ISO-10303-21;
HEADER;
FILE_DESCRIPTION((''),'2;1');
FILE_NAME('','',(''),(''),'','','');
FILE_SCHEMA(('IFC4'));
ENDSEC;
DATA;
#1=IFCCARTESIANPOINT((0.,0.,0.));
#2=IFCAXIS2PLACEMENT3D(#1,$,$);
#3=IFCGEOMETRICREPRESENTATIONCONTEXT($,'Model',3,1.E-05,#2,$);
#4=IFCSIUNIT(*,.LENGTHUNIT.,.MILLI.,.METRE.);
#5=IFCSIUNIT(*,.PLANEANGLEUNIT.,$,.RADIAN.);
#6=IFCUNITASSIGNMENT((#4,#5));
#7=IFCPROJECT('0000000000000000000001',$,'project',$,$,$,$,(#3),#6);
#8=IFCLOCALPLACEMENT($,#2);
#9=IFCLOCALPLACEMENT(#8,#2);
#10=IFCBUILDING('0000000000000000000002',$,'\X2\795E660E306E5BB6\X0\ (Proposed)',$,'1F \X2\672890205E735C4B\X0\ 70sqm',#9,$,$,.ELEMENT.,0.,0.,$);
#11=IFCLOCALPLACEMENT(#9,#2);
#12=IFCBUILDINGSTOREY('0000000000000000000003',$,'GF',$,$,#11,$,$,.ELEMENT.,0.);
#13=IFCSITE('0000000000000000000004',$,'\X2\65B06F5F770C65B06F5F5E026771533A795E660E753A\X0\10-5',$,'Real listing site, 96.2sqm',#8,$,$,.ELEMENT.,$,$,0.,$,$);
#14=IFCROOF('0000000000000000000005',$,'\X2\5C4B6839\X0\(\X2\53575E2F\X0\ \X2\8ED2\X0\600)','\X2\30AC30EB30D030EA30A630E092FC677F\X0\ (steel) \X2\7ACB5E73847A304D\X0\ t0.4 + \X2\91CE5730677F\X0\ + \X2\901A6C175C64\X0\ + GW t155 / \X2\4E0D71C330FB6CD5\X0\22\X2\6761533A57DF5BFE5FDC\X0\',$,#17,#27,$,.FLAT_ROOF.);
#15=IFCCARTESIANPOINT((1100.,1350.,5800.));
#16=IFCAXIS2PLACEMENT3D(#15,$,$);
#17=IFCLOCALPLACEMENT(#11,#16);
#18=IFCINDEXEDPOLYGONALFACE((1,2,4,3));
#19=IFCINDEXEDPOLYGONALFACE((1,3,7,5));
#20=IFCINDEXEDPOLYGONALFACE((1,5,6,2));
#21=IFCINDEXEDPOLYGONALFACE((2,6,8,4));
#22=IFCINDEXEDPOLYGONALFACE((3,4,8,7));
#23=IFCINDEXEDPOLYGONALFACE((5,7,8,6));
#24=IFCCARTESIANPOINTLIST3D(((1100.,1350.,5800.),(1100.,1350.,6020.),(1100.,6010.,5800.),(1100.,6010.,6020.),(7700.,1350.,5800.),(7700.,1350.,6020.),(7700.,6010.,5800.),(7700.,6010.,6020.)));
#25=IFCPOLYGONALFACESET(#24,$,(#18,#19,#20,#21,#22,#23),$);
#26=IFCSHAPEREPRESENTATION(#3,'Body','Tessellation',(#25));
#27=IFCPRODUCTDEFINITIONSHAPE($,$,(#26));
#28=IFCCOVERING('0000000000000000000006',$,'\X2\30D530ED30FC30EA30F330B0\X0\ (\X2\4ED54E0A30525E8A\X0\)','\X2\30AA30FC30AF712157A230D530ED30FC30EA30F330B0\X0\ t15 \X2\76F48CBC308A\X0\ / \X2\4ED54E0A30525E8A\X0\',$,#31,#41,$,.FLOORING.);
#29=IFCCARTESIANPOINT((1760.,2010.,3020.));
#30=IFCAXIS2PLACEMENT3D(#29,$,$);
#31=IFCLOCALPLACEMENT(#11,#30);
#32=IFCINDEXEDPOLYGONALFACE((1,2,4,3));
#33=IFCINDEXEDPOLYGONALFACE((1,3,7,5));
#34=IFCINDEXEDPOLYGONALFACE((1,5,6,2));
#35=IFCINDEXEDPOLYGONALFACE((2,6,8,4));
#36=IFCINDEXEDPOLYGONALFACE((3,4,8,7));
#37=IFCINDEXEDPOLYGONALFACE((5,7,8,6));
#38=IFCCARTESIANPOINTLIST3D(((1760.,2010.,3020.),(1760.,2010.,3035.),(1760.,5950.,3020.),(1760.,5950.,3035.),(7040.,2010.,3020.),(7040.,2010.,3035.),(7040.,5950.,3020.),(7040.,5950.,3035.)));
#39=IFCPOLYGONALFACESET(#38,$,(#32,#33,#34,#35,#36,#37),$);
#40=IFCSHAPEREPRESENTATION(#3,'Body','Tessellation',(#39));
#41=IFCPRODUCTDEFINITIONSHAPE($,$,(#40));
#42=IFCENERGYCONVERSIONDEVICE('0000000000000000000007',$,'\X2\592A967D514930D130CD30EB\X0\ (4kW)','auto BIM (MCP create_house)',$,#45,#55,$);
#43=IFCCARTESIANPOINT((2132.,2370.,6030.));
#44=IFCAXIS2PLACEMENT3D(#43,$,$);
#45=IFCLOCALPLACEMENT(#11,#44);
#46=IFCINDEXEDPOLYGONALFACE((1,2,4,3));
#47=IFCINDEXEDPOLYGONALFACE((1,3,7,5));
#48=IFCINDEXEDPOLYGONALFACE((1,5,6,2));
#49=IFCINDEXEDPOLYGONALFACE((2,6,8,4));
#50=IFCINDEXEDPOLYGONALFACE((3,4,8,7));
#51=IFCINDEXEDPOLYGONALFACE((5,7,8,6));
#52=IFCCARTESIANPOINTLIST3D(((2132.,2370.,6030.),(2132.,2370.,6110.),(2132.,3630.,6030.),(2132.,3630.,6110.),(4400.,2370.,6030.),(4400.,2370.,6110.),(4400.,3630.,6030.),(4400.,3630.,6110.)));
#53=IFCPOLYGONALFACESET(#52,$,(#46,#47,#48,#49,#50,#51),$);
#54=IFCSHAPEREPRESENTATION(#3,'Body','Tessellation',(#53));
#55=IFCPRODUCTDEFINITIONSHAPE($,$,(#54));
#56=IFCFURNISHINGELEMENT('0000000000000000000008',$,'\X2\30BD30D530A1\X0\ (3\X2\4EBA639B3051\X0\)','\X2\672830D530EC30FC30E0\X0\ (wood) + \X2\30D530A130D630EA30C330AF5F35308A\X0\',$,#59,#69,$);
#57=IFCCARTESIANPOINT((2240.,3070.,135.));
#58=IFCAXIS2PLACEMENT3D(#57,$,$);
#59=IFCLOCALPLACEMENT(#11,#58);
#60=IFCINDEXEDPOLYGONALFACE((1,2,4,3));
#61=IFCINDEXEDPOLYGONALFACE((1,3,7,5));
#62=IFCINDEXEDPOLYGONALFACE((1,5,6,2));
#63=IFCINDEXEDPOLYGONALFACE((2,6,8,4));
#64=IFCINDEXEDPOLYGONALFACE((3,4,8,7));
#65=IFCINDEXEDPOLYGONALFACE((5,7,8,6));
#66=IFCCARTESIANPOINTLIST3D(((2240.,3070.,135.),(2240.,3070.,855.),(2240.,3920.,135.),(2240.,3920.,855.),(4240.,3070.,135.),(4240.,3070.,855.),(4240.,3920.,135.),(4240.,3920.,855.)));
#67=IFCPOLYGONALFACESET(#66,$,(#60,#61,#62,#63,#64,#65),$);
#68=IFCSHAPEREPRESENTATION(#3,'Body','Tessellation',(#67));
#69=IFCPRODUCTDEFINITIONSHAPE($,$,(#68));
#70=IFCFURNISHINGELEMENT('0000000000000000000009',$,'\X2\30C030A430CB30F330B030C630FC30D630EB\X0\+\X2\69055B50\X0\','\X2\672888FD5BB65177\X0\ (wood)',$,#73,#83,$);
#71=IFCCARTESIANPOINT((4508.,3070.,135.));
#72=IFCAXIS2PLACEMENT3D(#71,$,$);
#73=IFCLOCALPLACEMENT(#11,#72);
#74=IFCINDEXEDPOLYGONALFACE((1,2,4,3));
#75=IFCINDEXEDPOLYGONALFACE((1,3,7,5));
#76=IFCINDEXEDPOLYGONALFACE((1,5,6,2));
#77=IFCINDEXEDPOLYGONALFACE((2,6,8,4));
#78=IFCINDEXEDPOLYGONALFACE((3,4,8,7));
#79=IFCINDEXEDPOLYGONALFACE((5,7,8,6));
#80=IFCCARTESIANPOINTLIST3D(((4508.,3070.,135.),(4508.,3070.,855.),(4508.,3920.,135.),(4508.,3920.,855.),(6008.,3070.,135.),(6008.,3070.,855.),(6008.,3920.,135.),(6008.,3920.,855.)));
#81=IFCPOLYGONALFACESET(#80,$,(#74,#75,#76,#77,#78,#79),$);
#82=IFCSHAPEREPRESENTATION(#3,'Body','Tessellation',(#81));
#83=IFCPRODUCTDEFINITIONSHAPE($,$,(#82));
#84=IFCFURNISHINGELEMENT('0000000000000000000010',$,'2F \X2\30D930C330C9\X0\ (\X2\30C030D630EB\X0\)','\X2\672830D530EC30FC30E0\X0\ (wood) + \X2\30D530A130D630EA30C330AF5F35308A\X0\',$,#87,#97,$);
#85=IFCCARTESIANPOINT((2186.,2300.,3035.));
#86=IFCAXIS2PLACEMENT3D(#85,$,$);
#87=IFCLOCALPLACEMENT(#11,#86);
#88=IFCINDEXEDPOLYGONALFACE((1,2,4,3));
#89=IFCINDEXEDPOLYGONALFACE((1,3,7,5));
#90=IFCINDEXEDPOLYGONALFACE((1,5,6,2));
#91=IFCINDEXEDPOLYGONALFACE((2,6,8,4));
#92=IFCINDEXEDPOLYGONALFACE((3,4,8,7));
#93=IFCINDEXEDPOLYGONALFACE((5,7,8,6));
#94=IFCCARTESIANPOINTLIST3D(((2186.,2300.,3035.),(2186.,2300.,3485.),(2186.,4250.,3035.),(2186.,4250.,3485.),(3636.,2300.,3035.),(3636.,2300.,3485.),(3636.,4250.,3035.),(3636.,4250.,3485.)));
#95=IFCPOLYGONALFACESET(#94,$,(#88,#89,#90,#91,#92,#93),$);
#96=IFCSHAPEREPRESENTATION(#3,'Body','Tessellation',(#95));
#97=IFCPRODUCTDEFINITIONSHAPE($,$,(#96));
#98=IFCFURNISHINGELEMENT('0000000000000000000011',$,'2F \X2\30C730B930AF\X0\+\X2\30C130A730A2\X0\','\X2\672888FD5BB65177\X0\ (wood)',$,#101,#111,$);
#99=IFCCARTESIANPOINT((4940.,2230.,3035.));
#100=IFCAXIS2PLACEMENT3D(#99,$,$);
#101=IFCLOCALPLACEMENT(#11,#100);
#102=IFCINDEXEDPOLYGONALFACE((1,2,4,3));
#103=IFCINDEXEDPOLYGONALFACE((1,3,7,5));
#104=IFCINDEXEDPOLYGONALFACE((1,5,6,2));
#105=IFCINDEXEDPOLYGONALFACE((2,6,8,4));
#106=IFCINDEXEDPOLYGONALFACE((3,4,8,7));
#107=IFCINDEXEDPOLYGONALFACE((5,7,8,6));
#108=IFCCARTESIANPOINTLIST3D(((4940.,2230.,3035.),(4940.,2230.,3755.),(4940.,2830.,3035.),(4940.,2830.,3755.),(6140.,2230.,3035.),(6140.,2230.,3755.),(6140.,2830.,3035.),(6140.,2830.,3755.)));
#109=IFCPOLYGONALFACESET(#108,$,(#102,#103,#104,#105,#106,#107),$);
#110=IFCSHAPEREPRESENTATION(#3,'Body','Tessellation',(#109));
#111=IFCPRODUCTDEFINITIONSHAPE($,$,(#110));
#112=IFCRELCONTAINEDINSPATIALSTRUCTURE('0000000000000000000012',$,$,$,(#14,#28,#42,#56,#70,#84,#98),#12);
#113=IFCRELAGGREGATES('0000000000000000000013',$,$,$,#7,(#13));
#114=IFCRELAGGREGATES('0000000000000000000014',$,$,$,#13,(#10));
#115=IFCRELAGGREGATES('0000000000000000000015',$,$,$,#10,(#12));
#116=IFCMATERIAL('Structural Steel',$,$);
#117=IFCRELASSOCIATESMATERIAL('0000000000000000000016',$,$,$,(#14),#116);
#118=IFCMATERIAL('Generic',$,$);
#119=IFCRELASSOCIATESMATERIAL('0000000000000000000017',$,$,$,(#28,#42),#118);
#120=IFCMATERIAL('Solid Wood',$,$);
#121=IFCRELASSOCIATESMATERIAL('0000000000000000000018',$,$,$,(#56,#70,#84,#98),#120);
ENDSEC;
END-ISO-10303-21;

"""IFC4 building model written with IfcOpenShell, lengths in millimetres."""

from ifc_helpers import new_model, si_unit, frame, frame_2d, origin, place, context, project, spatial, rectangle, extrude, material, element, save


model = new_model("IFC4")

# Units and contexts
model_context = context("Model", 3, precision=1e-05, world=origin())
ifc_project = project(units=[si_unit("LENGTHUNIT", "METRE", prefix="MILLI"), si_unit("PLANEANGLEUNIT", "RADIAN")], contexts=[model_context])

# Site, building, storey
site_placement = place(None, origin())
site = spatial("IfcSite", under=ifc_project, at=site_placement, Name="新潟県新潟市東区神明町10-5", ObjectType="Real listing site, 96.2sqm", CompositionType="ELEMENT", RefElevation=0.0)
building_placement = place(site_placement, origin())
building = spatial("IfcBuilding", under=site, at=building_placement, Name="神明の家 (Proposed)", ObjectType="1F 木造平屋 70sqm", CompositionType="ELEMENT", ElevationOfRefHeight=0.0, ElevationOfTerrain=0.0)
storey_placement = place(building_placement, origin())
storey = spatial("IfcBuildingStorey", under=building, at=storey_placement, Name="GF", CompositionType="ELEMENT", Elevation=0.0)

# Shared definitions
ifc_material_1 = material(Name="Solid Wood")

# Shared definitions
ifc_material_2 = material(Name="Generic")

# Roof
ifc_material_3 = material(Name="Structural Steel")
for number, where, name in (
    (1, (1100.0, 1350.0, 5800.0), "屋根(南帯 軒600)"),
):
    element("IfcRoof", number, at=place(storey_placement, frame(where)), inside=storey, material=ifc_material_3, Name=name, Description="ガルバリウム鋼板 (steel) 立平葺き t0.4 + 野地板 + 通気層 + GW t155 / 不燃・法22条区域対応", PredefinedType="FLAT_ROOF", context=model_context, shape_type="SweptSolid", body=[
        extrude(rectangle(XDim=6600.0, YDim=4660.0, at=frame_2d((3300.0, 2330.0))), frame((1100.0, 1350.0, 5800.0)), (0.0, 0.0, 1.0), 220.0),
    ])

# Covering
covering_placement = place(storey_placement, frame((1760.0, 2010.0, 3020.0)))
element("IfcCovering", 2, at=covering_placement, inside=storey, material=ifc_material_2, Name="フローリング (仕上げ床)", Description="オーク無垢フローリング t15 直貼り / 仕上げ床", PredefinedType="FLOORING", context=model_context, shape_type="SweptSolid", body=[
    extrude(rectangle(XDim=5280.0, YDim=3940.0, at=frame_2d((2640.0, 1970.0))), frame((1760.0, 2010.0, 3020.0)), (0.0, 0.0, 1.0), 15.0),
])

# Energy conversion device
energy_conversion_device_placement = place(storey_placement, frame((2132.0, 2370.0, 6030.0)))
element("IfcEnergyConversionDevice", 3, at=energy_conversion_device_placement, inside=storey, material=ifc_material_2, Name="太陽光パネル (4kW)", Description="auto BIM (MCP create_house)", context=model_context, shape_type="SweptSolid", body=[
    extrude(rectangle(XDim=2268.0, YDim=1260.0, at=frame_2d((1134.0, 630.0))), frame((2132.0, 2370.0, 6030.0)), (0.0, 0.0, 1.0), 80.0),
])

# Furnishing elements
furnishing_1_placement = place(storey_placement, frame((2240.0, 3070.0, 135.0)))
element("IfcFurnishingElement", 4, at=furnishing_1_placement, inside=storey, material=ifc_material_1, Name="ソファ (3人掛け)", Description="木フレーム (wood) + ファブリック張り", context=model_context, shape_type="SweptSolid", body=[
    extrude(rectangle(XDim=2000.0, YDim=850.0, at=frame_2d((1000.0, 425.0))), frame((2240.0, 3070.0, 135.0)), (0.0, 0.0, 1.0), 720.0),
])
furnishing_2_placement = place(storey_placement, frame((4508.0, 3070.0, 135.0)))
element("IfcFurnishingElement", 5, at=furnishing_2_placement, inside=storey, material=ifc_material_1, Name="ダイニングテーブル+椅子", Description="木製家具 (wood)", context=model_context, shape_type="SweptSolid", body=[
    extrude(rectangle(XDim=1500.0, YDim=850.0, at=frame_2d((750.0, 425.0))), frame((4508.0, 3070.0, 135.0)), (0.0, 0.0, 1.0), 720.0),
])
furnishing_3_placement = place(storey_placement, frame((2186.0, 2300.0, 3035.0)))
element("IfcFurnishingElement", 6, at=furnishing_3_placement, inside=storey, material=ifc_material_1, Name="2F ベッド (ダブル)", Description="木フレーム (wood) + ファブリック張り", context=model_context, shape_type="SweptSolid", body=[
    extrude(rectangle(XDim=1450.0, YDim=1950.0, at=frame_2d((725.0, 975.0))), frame((2186.0, 2300.0, 3035.0)), (0.0, 0.0, 1.0), 450.0),
])
furnishing_4_placement = place(storey_placement, frame((4940.0, 2230.0, 3035.0)))
element("IfcFurnishingElement", 7, at=furnishing_4_placement, inside=storey, material=ifc_material_1, Name="2F デスク+チェア", Description="木製家具 (wood)", context=model_context, shape_type="SweptSolid", body=[
    extrude(rectangle(XDim=1200.0, YDim=600.0, at=frame_2d((600.0, 300.0))), frame((4940.0, 2230.0, 3035.0)), (0.0, 0.0, 1.0), 720.0),
])

save(model, "model.ifc")
